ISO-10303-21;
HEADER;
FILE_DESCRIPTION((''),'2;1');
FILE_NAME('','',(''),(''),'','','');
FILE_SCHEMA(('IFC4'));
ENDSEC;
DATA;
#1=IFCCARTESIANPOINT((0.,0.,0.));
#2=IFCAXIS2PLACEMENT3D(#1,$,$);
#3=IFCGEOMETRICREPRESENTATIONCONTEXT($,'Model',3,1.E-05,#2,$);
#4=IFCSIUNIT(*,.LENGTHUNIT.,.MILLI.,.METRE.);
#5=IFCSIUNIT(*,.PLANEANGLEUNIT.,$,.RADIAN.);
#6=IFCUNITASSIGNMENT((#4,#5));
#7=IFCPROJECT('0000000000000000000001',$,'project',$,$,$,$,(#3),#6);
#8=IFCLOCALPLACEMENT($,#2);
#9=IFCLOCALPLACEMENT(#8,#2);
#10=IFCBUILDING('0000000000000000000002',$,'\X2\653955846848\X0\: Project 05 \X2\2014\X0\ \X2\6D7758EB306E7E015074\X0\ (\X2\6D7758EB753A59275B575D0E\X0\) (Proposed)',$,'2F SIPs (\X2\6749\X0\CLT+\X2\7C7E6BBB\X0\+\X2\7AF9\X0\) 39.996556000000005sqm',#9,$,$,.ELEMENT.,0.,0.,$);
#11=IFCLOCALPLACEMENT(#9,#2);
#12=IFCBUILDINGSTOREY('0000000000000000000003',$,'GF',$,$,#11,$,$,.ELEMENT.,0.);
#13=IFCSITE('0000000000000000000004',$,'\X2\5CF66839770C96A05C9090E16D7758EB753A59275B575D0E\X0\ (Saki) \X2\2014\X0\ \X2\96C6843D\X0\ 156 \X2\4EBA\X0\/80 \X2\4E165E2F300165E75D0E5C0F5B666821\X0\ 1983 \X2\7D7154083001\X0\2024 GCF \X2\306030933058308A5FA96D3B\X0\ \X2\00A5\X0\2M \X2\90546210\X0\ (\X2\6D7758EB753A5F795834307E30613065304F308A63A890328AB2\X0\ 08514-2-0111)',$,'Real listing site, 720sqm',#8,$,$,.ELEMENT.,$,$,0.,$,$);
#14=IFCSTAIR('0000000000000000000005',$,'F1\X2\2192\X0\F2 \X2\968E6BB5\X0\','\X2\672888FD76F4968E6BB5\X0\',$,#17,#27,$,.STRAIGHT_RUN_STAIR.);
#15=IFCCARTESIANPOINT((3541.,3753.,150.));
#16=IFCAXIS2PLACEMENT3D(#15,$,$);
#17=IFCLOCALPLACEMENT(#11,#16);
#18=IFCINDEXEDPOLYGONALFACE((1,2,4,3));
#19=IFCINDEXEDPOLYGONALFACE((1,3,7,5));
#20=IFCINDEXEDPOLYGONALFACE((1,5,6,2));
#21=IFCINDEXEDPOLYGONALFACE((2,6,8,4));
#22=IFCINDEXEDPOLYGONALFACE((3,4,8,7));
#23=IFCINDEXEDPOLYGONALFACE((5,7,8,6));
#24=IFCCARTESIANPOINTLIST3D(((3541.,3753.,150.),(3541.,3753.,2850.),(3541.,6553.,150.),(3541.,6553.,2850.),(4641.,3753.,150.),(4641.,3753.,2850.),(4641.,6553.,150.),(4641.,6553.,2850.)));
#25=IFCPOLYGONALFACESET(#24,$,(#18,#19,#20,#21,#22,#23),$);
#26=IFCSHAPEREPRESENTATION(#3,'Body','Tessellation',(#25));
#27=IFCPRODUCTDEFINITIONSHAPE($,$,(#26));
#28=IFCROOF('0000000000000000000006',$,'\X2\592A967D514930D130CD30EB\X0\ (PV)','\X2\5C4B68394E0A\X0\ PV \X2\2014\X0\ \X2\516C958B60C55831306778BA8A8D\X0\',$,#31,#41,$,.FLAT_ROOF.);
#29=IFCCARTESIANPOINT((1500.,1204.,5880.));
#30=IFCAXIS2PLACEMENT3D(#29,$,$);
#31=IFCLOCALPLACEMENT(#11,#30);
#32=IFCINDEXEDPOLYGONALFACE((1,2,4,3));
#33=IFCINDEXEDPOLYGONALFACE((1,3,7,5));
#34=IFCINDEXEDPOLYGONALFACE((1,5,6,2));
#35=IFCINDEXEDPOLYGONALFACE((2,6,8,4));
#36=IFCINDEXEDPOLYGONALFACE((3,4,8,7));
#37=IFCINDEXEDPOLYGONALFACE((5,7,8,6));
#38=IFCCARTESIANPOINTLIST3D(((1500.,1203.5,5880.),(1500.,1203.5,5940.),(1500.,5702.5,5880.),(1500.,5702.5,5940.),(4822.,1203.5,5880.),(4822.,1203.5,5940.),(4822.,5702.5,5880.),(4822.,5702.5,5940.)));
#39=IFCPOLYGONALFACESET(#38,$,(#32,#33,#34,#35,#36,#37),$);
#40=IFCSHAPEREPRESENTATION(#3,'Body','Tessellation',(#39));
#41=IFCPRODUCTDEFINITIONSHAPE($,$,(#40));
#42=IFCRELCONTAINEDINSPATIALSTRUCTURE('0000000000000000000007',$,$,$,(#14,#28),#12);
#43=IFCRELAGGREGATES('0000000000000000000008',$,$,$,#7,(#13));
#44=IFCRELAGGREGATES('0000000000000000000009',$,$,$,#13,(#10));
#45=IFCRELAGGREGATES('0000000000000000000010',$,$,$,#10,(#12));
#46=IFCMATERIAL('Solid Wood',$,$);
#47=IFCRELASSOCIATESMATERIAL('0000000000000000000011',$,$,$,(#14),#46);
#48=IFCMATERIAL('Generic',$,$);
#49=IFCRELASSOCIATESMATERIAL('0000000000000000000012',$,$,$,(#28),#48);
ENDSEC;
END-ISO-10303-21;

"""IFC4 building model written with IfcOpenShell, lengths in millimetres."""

from ifc_helpers import new_model, si_unit, frame, frame_2d, origin, place, context, project, spatial, rectangle, extrude, material, element, save


model = new_model("IFC4")

# Units and contexts
model_context = context("Model", 3, precision=1e-05, world=origin())
ifc_project = project(units=[si_unit("LENGTHUNIT", "METRE", prefix="MILLI"), si_unit("PLANEANGLEUNIT", "RADIAN")], contexts=[model_context])

# Site, building, storey
site_placement = place(None, origin())
site = spatial("IfcSite", under=ifc_project, at=site_placement, Name="島根県隠岐郡海士町大字崎 (Saki) — 集落 156 人/80 世帯、旧崎小学校 1983 統合、2024 GCF だんじり復活 ¥2M 達成 (海士町役場まちづくり推進課 08514-2-0111)", ObjectType="Real listing site, 720sqm", CompositionType="ELEMENT", RefElevation=0.0)
building_placement = place(site_placement, origin())
building = spatial("IfcBuilding", under=site, at=building_placement, Name="改善案: Project 05 — 海士の縁側 (海士町大字崎) (Proposed)", ObjectType="2F SIPs (杉CLT+籾殻+竹) 39.996556000000005sqm", CompositionType="ELEMENT", ElevationOfRefHeight=0.0, ElevationOfTerrain=0.0)
storey_placement = place(building_placement, origin())
storey = spatial("IfcBuildingStorey", under=building, at=storey_placement, Name="GF", CompositionType="ELEMENT", Elevation=0.0)

# Shared definitions
ifc_material_1 = material(Name="Generic")

# Stair
ifc_material_2 = material(Name="Solid Wood")
stair_placement = place(storey_placement, frame((3541.0, 3753.0, 150.0)))
element("IfcStair", 1, at=stair_placement, inside=storey, material=ifc_material_2, Name="F1→F2 階段", Description="木製直階段", PredefinedType="STRAIGHT_RUN_STAIR", context=model_context, shape_type="SweptSolid", body=[
    extrude(rectangle(XDim=1100.0, YDim=2800.0, at=frame_2d((550.0, 1400.0))), frame((3541.0, 3753.0, 150.0)), (0.0, 0.0, 1.0), 2700.0),
])

# Roof
roof_placement = place(storey_placement, frame((1500.0, 1204.0, 5880.0)))
element("IfcRoof", 2, at=roof_placement, inside=storey, material=ifc_material_1, Name="太陽光パネル (PV)", Description="屋根上 PV — 公開情報で確認", PredefinedType="FLAT_ROOF", context=model_context, shape_type="SweptSolid", body=[
    extrude(rectangle(XDim=3322.0, YDim=4499.0, at=frame_2d((1661.0, 2249.0))), frame((1500.0, 1204.0, 5880.0)), (0.0, 0.0, 1.0), 60.0),
])

save(model, "model.ifc")
